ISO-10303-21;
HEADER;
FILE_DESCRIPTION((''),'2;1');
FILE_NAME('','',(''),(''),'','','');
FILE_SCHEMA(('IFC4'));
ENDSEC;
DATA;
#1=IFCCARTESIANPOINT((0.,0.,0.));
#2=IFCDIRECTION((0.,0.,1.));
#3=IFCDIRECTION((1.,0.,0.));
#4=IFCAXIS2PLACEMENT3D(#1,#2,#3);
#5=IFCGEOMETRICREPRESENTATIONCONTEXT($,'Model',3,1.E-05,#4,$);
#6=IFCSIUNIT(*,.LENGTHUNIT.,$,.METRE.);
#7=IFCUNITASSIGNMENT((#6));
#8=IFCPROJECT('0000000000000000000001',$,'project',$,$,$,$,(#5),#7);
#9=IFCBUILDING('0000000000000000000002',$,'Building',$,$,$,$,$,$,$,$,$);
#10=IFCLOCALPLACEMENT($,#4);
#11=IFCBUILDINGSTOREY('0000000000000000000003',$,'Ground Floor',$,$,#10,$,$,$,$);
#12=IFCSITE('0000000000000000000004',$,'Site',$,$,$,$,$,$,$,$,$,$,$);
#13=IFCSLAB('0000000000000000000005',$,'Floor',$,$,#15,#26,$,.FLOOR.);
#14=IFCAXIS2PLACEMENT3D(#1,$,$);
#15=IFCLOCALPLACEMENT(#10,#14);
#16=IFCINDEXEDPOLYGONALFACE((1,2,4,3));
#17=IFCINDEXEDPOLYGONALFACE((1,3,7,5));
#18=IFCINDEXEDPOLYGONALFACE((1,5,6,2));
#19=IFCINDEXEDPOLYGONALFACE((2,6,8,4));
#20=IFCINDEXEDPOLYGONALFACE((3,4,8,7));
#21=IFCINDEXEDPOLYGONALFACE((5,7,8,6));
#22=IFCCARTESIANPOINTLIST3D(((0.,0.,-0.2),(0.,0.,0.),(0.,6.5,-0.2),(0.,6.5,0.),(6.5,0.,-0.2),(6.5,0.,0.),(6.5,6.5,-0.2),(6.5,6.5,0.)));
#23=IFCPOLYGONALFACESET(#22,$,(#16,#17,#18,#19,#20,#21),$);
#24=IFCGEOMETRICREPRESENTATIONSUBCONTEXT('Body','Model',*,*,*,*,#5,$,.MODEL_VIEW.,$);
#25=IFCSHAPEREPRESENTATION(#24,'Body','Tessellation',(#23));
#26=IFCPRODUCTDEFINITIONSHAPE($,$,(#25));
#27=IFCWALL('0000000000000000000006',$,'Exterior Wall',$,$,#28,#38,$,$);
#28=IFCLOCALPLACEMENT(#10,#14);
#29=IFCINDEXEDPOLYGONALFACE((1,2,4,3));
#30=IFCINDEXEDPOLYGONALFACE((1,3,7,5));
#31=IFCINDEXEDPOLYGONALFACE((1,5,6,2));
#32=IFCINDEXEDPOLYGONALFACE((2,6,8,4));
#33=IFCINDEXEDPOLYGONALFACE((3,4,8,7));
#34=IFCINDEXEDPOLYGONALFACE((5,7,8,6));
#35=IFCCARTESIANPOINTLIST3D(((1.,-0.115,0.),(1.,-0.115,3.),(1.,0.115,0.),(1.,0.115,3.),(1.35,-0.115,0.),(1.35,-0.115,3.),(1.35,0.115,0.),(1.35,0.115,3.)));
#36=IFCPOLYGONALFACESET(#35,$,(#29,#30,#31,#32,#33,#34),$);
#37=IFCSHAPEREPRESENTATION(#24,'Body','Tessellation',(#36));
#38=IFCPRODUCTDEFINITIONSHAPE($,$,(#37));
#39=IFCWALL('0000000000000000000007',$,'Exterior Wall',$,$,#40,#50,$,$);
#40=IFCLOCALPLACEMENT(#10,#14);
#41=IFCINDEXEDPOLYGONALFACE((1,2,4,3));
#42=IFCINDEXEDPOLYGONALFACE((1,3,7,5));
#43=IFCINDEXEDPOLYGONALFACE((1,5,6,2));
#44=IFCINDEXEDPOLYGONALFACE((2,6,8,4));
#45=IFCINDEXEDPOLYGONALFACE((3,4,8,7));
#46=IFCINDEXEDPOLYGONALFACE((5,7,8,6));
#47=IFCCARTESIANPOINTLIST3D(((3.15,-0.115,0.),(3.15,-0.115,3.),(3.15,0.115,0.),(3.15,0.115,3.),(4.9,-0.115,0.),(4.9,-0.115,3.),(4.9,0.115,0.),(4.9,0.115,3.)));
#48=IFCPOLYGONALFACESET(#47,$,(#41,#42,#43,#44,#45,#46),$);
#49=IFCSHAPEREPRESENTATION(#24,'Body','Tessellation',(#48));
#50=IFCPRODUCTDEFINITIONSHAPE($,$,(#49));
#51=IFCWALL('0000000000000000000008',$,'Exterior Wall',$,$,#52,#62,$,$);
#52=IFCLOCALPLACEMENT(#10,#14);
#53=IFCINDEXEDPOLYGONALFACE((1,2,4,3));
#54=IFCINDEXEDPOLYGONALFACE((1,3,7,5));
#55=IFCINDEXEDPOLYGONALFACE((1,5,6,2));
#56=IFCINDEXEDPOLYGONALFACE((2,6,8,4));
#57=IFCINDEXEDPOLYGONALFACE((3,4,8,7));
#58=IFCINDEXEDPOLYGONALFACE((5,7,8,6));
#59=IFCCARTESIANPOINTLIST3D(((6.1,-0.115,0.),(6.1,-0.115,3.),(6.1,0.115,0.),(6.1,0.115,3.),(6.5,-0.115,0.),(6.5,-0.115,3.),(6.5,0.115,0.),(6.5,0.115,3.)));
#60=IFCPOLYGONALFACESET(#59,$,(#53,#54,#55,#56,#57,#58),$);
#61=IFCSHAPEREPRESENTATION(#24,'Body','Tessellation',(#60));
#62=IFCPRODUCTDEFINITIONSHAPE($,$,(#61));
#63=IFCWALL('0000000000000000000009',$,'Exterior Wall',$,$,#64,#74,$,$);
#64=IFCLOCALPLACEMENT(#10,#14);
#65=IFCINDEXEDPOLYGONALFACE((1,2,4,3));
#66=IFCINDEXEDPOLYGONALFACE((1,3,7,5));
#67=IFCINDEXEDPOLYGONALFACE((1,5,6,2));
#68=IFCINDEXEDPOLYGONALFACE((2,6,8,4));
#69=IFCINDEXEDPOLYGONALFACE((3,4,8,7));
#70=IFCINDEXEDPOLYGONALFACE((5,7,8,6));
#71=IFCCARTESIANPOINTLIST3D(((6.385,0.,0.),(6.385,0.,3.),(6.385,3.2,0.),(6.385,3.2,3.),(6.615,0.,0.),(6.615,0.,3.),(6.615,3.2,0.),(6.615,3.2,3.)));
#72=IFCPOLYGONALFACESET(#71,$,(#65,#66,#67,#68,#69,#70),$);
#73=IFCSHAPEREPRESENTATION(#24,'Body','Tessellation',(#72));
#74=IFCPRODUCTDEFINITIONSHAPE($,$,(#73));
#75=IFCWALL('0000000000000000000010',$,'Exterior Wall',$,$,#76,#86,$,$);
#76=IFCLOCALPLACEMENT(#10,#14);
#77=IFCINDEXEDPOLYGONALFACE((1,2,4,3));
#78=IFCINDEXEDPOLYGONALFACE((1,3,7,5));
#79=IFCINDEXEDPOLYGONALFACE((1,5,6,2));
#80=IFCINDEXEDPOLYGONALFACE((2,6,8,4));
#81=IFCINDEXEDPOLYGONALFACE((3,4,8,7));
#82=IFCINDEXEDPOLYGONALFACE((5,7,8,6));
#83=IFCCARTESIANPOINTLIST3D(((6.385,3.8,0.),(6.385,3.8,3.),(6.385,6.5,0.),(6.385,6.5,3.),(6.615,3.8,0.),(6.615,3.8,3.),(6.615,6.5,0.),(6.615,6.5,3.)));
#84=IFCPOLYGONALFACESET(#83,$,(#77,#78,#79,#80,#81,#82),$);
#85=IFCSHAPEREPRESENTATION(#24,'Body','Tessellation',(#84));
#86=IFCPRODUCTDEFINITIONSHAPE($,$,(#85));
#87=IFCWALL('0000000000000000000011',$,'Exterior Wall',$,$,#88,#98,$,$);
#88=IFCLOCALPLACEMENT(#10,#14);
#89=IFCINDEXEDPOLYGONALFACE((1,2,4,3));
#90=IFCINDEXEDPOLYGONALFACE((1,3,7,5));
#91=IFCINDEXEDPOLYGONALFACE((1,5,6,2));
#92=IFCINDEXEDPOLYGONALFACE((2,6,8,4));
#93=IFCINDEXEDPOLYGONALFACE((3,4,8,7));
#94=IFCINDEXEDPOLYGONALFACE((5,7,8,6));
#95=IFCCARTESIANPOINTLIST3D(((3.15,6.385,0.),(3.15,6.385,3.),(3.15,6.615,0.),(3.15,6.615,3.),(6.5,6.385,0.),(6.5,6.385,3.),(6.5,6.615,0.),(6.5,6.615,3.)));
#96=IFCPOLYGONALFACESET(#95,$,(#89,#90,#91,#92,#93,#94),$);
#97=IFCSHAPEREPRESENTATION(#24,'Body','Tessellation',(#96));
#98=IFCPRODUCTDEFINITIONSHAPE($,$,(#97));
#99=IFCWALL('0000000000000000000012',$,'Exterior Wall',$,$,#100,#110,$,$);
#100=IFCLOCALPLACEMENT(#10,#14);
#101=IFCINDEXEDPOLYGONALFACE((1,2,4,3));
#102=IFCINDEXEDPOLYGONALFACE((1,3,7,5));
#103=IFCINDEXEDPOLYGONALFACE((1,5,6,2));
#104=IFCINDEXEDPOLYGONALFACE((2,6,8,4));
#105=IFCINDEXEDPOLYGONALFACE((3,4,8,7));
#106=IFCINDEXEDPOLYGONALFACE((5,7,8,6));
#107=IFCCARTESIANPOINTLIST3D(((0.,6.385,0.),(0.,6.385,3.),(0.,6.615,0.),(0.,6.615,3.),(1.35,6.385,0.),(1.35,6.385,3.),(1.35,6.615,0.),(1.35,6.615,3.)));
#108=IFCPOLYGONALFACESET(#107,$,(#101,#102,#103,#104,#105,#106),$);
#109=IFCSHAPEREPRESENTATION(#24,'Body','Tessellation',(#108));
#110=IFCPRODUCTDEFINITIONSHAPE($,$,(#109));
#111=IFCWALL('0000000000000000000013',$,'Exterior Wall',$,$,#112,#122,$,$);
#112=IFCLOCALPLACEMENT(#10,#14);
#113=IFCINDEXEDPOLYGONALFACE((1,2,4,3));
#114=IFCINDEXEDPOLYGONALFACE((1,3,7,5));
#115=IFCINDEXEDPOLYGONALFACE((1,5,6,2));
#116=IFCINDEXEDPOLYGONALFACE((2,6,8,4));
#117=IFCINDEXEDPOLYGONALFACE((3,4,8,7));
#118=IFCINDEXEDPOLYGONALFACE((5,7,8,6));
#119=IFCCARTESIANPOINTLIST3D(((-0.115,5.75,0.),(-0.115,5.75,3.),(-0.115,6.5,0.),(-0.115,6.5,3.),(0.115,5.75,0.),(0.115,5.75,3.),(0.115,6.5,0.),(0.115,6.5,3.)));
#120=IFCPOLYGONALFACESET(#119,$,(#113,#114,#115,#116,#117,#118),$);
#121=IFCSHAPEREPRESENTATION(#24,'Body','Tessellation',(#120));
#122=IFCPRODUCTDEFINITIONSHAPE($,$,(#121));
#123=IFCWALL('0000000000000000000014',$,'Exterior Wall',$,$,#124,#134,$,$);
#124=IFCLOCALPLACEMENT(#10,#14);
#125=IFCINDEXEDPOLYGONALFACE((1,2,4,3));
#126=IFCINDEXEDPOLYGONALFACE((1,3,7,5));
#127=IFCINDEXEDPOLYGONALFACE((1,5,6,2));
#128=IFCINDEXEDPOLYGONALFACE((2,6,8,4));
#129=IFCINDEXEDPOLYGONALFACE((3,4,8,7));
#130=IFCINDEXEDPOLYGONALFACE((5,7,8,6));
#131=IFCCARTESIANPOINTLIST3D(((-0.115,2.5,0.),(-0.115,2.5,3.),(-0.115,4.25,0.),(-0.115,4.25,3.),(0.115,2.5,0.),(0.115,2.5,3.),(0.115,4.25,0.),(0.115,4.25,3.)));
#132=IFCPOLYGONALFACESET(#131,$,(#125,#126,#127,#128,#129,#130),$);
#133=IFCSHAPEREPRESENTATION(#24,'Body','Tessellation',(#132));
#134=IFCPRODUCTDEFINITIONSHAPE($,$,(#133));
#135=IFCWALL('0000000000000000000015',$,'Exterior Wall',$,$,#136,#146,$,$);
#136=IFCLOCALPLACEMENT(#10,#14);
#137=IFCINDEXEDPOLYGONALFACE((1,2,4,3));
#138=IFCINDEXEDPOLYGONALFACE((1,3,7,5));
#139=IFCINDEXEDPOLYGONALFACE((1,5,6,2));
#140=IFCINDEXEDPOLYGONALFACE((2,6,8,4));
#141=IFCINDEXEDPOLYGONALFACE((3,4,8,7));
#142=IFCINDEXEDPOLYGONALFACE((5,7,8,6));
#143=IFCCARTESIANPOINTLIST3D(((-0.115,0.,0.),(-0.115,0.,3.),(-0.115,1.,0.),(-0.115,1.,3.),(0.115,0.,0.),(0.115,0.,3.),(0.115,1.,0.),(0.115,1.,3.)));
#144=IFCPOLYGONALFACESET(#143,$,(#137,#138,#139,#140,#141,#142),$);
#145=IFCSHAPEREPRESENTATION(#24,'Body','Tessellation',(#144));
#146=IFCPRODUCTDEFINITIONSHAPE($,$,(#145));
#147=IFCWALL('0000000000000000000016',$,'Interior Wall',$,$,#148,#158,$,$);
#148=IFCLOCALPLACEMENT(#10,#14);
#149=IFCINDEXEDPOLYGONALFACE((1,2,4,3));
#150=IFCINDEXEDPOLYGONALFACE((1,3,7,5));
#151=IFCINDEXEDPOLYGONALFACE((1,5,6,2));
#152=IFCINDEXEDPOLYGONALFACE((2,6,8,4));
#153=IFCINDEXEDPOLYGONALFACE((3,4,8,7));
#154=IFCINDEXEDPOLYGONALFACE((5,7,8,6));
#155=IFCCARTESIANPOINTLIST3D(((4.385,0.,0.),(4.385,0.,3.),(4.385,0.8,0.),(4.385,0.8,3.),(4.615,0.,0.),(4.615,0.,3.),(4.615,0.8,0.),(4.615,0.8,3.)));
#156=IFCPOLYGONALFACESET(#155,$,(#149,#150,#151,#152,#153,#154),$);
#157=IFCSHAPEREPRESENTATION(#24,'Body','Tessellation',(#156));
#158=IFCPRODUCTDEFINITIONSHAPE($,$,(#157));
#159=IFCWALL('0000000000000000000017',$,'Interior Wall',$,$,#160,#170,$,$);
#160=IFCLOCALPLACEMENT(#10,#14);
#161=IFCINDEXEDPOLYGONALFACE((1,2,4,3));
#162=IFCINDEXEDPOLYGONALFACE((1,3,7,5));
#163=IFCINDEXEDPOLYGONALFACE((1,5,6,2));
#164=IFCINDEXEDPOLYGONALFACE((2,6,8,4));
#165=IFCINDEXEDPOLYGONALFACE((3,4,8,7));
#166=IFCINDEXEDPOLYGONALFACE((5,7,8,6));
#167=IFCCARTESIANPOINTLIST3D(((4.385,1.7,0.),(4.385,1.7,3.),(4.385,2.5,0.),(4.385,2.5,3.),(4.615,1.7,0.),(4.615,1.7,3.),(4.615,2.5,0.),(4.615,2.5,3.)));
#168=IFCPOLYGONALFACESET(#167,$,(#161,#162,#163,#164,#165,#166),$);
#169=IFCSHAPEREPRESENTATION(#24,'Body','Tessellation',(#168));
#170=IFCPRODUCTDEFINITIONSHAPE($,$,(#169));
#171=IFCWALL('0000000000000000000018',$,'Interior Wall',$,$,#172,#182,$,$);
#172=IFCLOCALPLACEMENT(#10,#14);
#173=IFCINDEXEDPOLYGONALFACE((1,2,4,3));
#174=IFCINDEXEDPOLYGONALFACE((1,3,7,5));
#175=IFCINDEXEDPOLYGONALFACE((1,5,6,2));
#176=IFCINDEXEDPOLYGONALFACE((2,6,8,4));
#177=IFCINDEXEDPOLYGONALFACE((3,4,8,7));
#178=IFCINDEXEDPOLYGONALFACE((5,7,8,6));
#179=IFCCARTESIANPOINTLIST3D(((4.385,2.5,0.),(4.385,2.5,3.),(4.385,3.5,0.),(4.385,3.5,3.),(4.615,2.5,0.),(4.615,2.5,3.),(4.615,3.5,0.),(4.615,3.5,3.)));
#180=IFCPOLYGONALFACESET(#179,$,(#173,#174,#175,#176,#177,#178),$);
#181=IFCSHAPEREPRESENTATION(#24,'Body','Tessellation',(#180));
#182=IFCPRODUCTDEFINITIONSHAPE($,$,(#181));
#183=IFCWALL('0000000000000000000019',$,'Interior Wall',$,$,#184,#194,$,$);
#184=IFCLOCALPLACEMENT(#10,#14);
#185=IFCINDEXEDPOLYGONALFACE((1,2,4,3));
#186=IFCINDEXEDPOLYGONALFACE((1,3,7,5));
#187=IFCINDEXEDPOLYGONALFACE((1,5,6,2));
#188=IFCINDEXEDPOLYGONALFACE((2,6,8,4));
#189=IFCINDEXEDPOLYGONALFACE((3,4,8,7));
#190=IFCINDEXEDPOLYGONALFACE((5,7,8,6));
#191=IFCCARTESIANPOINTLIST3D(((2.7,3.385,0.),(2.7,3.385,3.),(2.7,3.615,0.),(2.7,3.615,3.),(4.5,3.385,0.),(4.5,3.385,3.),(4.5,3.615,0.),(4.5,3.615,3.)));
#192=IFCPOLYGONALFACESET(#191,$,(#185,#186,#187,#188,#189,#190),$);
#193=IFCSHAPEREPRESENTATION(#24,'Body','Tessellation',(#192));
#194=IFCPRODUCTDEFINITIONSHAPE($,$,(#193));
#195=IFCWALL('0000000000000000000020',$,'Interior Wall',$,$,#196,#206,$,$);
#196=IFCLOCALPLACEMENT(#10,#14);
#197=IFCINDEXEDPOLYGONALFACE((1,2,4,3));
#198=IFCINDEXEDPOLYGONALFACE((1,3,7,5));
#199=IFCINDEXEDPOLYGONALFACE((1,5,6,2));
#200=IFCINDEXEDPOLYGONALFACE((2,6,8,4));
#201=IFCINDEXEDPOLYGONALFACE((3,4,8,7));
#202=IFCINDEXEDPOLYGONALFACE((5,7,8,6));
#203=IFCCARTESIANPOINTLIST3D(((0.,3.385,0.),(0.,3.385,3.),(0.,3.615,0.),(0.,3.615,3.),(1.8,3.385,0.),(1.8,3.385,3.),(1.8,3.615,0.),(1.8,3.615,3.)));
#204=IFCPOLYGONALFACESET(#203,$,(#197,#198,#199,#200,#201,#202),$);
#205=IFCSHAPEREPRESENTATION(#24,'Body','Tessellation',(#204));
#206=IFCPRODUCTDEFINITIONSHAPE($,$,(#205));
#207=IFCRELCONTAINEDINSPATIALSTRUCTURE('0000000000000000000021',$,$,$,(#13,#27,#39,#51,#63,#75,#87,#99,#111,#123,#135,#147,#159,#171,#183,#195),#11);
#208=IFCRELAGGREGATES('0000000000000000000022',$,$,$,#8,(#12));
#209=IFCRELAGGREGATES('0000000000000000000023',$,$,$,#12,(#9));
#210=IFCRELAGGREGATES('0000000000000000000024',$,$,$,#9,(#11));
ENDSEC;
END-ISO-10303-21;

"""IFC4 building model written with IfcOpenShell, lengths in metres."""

from ifc_helpers import new_model, si_unit, frame, origin_with_axes, place, context, subcontext, project, spatial, indexed_curve, outline, extrude, element, save


model = new_model("IFC4")

# Units and contexts
model_context = context("Model", 3, precision=1e-05, world=origin_with_axes())
body_context = subcontext(model_context, "Body", "Model", "MODEL_VIEW")
ifc_project = project(units=[si_unit("LENGTHUNIT", "METRE")], contexts=[model_context])

# Site, building, storey
site = spatial("IfcSite", under=ifc_project, Name="Site")
building = spatial("IfcBuilding", under=site, Name="Building")
storey_placement = place(None, origin_with_axes())
storey = spatial("IfcBuildingStorey", under=building, at=storey_placement, Name="Ground Floor")

# Slab
slab_placement = place(storey_placement, frame((0.0, 0.0, -0.2), z_axis=(0.0, 0.0, 1.0), x_axis=(1.0, 0.0, 0.0)))
element("IfcSlab", 1, at=slab_placement, inside=storey, Name="Floor", PredefinedType="FLOOR", context=body_context, shape_type="SweptSolid", body=[
    extrude(outline(indexed_curve([(0.0, 0.0), (6.5, 0.0), (6.5, 6.5), (0.0, 6.5)])), None, (0.0, 0.0, 1.0), 0.2),
])

# Walls
wall_1_placement = place(storey_placement, frame((1.0, 0.0, 0.0), z_axis=(0.0, 0.0, 1.0), x_axis=(1.0, 0.0, 0.0)))
element("IfcWall", 2, at=wall_1_placement, inside=storey, Name="Exterior Wall", context=body_context, shape_type="SweptSolid", body=[
    extrude(outline(indexed_curve([(0.0, 0.0), (0.0, 0.23), (0.35, 0.23), (0.35, 0.0), (0.0, 0.0)], self_intersect=False)), frame((0.0, -0.115, 0.0), z_axis=(0.0, 0.0, 1.0), x_axis=(1.0, 0.0, 0.0)), (0.0, 0.0, 1.0), 3.0),
])
wall_2_placement = place(storey_placement, frame((3.15, 0.0, 0.0), z_axis=(0.0, 0.0, 1.0), x_axis=(1.0, 0.0, 0.0)))
element("IfcWall", 3, at=wall_2_placement, inside=storey, Name="Exterior Wall", context=body_context, shape_type="SweptSolid", body=[
    extrude(outline(indexed_curve([(0.0, 0.0), (0.0, 0.23), (1.75, 0.23), (1.75, 0.0), (0.0, 0.0)], self_intersect=False)), frame((0.0, -0.115, 0.0), z_axis=(0.0, 0.0, 1.0), x_axis=(1.0, 0.0, 0.0)), (0.0, 0.0, 1.0), 3.0),
])
wall_3_placement = place(storey_placement, frame((6.1, 0.0, 0.0), z_axis=(0.0, 0.0, 1.0), x_axis=(1.0, 0.0, 0.0)))
element("IfcWall", 4, at=wall_3_placement, inside=storey, Name="Exterior Wall", context=body_context, shape_type="SweptSolid", body=[
    extrude(outline(indexed_curve([(0.0, 0.0), (0.0, 0.23), (0.4, 0.23), (0.4, 0.0), (0.0, 0.0)], self_intersect=False)), frame((0.0, -0.115, 0.0), z_axis=(0.0, 0.0, 1.0), x_axis=(1.0, 0.0, 0.0)), (0.0, 0.0, 1.0), 3.0),
])
wall_4_placement = place(storey_placement, frame((6.5, 0.0, 0.0), z_axis=(0.0, 0.0, 1.0), x_axis=(0.0, 1.0, 0.0)))
element("IfcWall", 5, at=wall_4_placement, inside=storey, Name="Exterior Wall", context=body_context, shape_type="SweptSolid", body=[
    extrude(outline(indexed_curve([(0.0, 0.0), (0.0, 0.23), (3.2, 0.23), (3.2, 0.0), (0.0, 0.0)], self_intersect=False)), frame((0.0, -0.115, 0.0), z_axis=(0.0, 0.0, 1.0), x_axis=(1.0, 0.0, 0.0)), (0.0, 0.0, 1.0), 3.0),
])
wall_5_placement = place(storey_placement, frame((6.5, 3.8, 0.0), z_axis=(0.0, 0.0, 1.0), x_axis=(0.0, 1.0, 0.0)))
element("IfcWall", 6, at=wall_5_placement, inside=storey, Name="Exterior Wall", context=body_context, shape_type="SweptSolid", body=[
    extrude(outline(indexed_curve([(0.0, 0.0), (0.0, 0.23), (2.7, 0.23), (2.7, 0.0), (0.0, 0.0)], self_intersect=False)), frame((0.0, -0.115, 0.0), z_axis=(0.0, 0.0, 1.0), x_axis=(1.0, 0.0, 0.0)), (0.0, 0.0, 1.0), 3.0),
])
wall_6_placement = place(storey_placement, frame((6.5, 6.5, 0.0), z_axis=(0.0, 0.0, 1.0), x_axis=(-1.0, 0.0, 0.0)))
element("IfcWall", 7, at=wall_6_placement, inside=storey, Name="Exterior Wall", context=body_context, shape_type="SweptSolid", body=[
    extrude(outline(indexed_curve([(0.0, 0.0), (0.0, 0.23), (3.35, 0.23), (3.35, 0.0), (0.0, 0.0)], self_intersect=False)), frame((0.0, -0.115, 0.0), z_axis=(0.0, 0.0, 1.0), x_axis=(1.0, 0.0, 0.0)), (0.0, 0.0, 1.0), 3.0),
])
wall_7_placement = place(storey_placement, frame((1.35, 6.5, 0.0), z_axis=(0.0, 0.0, 1.0), x_axis=(-1.0, 0.0, 0.0)))
element("IfcWall", 8, at=wall_7_placement, inside=storey, Name="Exterior Wall", context=body_context, shape_type="SweptSolid", body=[
    extrude(outline(indexed_curve([(0.0, 0.0), (0.0, 0.23), (1.35, 0.23), (1.35, 0.0), (0.0, 0.0)], self_intersect=False)), frame((0.0, -0.115, 0.0), z_axis=(0.0, 0.0, 1.0), x_axis=(1.0, 0.0, 0.0)), (0.0, 0.0, 1.0), 3.0),
])
wall_8_placement = place(storey_placement, frame((0.0, 6.5, 0.0), z_axis=(0.0, 0.0, 1.0), x_axis=(0.0, -1.0, 0.0)))
element("IfcWall", 9, at=wall_8_placement, inside=storey, Name="Exterior Wall", context=body_context, shape_type="SweptSolid", body=[
    extrude(outline(indexed_curve([(0.0, 0.0), (0.0, 0.23), (0.75, 0.23), (0.75, 0.0), (0.0, 0.0)], self_intersect=False)), frame((0.0, -0.115, 0.0), z_axis=(0.0, 0.0, 1.0), x_axis=(1.0, 0.0, 0.0)), (0.0, 0.0, 1.0), 3.0),
])
wall_9_placement = place(storey_placement, frame((0.0, 4.25, 0.0), z_axis=(0.0, 0.0, 1.0), x_axis=(0.0, -1.0, 0.0)))
element("IfcWall", 10, at=wall_9_placement, inside=storey, Name="Exterior Wall", context=body_context, shape_type="SweptSolid", body=[
    extrude(outline(indexed_curve([(0.0, 0.0), (0.0, 0.23), (1.75, 0.23), (1.75, 0.0), (0.0, 0.0)], self_intersect=False)), frame((0.0, -0.115, 0.0), z_axis=(0.0, 0.0, 1.0), x_axis=(1.0, 0.0, 0.0)), (0.0, 0.0, 1.0), 3.0),
])
wall_10_placement = place(storey_placement, frame((0.0, 1.0, 0.0), z_axis=(0.0, 0.0, 1.0), x_axis=(0.0, -1.0, 0.0)))
element("IfcWall", 11, at=wall_10_placement, inside=storey, Name="Exterior Wall", context=body_context, shape_type="SweptSolid", body=[
    extrude(outline(indexed_curve([(0.0, 0.0), (0.0, 0.23), (1.0, 0.23), (1.0, 0.0), (0.0, 0.0)], self_intersect=False)), frame((0.0, -0.115, 0.0), z_axis=(0.0, 0.0, 1.0), x_axis=(1.0, 0.0, 0.0)), (0.0, 0.0, 1.0), 3.0),
])
for number, where, z_axis, x_axis, name in (
    (12, (4.5, 0.0, 0.0), (0.0, 0.0, 1.0), (0.0, 1.0, 0.0), "Interior Wall"),
    (13, (4.5, 1.7, 0.0), (0.0, 0.0, 1.0), (0.0, 1.0, 0.0), "Interior Wall"),
):
    element("IfcWall", number, at=place(storey_placement, frame(where, z_axis=z_axis, x_axis=x_axis)), inside=storey, Name=name, context=body_context, shape_type="SweptSolid", body=[
        extrude(outline(indexed_curve([(0.0, 0.0), (0.0, 0.23), (0.8, 0.23), (0.8, 0.0), (0.0, 0.0)], self_intersect=False)), frame((0.0, -0.115, 0.0), z_axis=(0.0, 0.0, 1.0), x_axis=(1.0, 0.0, 0.0)), (0.0, 0.0, 1.0), 3.0),
    ])
wall_11_placement = place(storey_placement, frame((4.5, 2.5, 0.0), z_axis=(0.0, 0.0, 1.0), x_axis=(0.0, 1.0, 0.0)))
element("IfcWall", 14, at=wall_11_placement, inside=storey, Name="Interior Wall", context=body_context, shape_type="SweptSolid", body=[
    extrude(outline(indexed_curve([(0.0, 0.0), (0.0, 0.23), (1.0, 0.23), (1.0, 0.0), (0.0, 0.0)], self_intersect=False)), frame((0.0, -0.115, 0.0), z_axis=(0.0, 0.0, 1.0), x_axis=(1.0, 0.0, 0.0)), (0.0, 0.0, 1.0), 3.0),
])
for number, where, z_axis, x_axis, name in (
    (15, (4.5, 3.5, 0.0), (0.0, 0.0, 1.0), (-1.0, 0.0, 0.0), "Interior Wall"),
    (16, (1.8, 3.5, 0.0), (0.0, 0.0, 1.0), (-1.0, 0.0, 0.0), "Interior Wall"),
):
    element("IfcWall", number, at=place(storey_placement, frame(where, z_axis=z_axis, x_axis=x_axis)), inside=storey, Name=name, context=body_context, shape_type="SweptSolid", body=[
        extrude(outline(indexed_curve([(0.0, 0.0), (0.0, 0.23), (1.8, 0.23), (1.8, 0.0), (0.0, 0.0)], self_intersect=False)), frame((0.0, -0.115, 0.0), z_axis=(0.0, 0.0, 1.0), x_axis=(1.0, 0.0, 0.0)), (0.0, 0.0, 1.0), 3.0),
    ])

save(model, "model.ifc")
